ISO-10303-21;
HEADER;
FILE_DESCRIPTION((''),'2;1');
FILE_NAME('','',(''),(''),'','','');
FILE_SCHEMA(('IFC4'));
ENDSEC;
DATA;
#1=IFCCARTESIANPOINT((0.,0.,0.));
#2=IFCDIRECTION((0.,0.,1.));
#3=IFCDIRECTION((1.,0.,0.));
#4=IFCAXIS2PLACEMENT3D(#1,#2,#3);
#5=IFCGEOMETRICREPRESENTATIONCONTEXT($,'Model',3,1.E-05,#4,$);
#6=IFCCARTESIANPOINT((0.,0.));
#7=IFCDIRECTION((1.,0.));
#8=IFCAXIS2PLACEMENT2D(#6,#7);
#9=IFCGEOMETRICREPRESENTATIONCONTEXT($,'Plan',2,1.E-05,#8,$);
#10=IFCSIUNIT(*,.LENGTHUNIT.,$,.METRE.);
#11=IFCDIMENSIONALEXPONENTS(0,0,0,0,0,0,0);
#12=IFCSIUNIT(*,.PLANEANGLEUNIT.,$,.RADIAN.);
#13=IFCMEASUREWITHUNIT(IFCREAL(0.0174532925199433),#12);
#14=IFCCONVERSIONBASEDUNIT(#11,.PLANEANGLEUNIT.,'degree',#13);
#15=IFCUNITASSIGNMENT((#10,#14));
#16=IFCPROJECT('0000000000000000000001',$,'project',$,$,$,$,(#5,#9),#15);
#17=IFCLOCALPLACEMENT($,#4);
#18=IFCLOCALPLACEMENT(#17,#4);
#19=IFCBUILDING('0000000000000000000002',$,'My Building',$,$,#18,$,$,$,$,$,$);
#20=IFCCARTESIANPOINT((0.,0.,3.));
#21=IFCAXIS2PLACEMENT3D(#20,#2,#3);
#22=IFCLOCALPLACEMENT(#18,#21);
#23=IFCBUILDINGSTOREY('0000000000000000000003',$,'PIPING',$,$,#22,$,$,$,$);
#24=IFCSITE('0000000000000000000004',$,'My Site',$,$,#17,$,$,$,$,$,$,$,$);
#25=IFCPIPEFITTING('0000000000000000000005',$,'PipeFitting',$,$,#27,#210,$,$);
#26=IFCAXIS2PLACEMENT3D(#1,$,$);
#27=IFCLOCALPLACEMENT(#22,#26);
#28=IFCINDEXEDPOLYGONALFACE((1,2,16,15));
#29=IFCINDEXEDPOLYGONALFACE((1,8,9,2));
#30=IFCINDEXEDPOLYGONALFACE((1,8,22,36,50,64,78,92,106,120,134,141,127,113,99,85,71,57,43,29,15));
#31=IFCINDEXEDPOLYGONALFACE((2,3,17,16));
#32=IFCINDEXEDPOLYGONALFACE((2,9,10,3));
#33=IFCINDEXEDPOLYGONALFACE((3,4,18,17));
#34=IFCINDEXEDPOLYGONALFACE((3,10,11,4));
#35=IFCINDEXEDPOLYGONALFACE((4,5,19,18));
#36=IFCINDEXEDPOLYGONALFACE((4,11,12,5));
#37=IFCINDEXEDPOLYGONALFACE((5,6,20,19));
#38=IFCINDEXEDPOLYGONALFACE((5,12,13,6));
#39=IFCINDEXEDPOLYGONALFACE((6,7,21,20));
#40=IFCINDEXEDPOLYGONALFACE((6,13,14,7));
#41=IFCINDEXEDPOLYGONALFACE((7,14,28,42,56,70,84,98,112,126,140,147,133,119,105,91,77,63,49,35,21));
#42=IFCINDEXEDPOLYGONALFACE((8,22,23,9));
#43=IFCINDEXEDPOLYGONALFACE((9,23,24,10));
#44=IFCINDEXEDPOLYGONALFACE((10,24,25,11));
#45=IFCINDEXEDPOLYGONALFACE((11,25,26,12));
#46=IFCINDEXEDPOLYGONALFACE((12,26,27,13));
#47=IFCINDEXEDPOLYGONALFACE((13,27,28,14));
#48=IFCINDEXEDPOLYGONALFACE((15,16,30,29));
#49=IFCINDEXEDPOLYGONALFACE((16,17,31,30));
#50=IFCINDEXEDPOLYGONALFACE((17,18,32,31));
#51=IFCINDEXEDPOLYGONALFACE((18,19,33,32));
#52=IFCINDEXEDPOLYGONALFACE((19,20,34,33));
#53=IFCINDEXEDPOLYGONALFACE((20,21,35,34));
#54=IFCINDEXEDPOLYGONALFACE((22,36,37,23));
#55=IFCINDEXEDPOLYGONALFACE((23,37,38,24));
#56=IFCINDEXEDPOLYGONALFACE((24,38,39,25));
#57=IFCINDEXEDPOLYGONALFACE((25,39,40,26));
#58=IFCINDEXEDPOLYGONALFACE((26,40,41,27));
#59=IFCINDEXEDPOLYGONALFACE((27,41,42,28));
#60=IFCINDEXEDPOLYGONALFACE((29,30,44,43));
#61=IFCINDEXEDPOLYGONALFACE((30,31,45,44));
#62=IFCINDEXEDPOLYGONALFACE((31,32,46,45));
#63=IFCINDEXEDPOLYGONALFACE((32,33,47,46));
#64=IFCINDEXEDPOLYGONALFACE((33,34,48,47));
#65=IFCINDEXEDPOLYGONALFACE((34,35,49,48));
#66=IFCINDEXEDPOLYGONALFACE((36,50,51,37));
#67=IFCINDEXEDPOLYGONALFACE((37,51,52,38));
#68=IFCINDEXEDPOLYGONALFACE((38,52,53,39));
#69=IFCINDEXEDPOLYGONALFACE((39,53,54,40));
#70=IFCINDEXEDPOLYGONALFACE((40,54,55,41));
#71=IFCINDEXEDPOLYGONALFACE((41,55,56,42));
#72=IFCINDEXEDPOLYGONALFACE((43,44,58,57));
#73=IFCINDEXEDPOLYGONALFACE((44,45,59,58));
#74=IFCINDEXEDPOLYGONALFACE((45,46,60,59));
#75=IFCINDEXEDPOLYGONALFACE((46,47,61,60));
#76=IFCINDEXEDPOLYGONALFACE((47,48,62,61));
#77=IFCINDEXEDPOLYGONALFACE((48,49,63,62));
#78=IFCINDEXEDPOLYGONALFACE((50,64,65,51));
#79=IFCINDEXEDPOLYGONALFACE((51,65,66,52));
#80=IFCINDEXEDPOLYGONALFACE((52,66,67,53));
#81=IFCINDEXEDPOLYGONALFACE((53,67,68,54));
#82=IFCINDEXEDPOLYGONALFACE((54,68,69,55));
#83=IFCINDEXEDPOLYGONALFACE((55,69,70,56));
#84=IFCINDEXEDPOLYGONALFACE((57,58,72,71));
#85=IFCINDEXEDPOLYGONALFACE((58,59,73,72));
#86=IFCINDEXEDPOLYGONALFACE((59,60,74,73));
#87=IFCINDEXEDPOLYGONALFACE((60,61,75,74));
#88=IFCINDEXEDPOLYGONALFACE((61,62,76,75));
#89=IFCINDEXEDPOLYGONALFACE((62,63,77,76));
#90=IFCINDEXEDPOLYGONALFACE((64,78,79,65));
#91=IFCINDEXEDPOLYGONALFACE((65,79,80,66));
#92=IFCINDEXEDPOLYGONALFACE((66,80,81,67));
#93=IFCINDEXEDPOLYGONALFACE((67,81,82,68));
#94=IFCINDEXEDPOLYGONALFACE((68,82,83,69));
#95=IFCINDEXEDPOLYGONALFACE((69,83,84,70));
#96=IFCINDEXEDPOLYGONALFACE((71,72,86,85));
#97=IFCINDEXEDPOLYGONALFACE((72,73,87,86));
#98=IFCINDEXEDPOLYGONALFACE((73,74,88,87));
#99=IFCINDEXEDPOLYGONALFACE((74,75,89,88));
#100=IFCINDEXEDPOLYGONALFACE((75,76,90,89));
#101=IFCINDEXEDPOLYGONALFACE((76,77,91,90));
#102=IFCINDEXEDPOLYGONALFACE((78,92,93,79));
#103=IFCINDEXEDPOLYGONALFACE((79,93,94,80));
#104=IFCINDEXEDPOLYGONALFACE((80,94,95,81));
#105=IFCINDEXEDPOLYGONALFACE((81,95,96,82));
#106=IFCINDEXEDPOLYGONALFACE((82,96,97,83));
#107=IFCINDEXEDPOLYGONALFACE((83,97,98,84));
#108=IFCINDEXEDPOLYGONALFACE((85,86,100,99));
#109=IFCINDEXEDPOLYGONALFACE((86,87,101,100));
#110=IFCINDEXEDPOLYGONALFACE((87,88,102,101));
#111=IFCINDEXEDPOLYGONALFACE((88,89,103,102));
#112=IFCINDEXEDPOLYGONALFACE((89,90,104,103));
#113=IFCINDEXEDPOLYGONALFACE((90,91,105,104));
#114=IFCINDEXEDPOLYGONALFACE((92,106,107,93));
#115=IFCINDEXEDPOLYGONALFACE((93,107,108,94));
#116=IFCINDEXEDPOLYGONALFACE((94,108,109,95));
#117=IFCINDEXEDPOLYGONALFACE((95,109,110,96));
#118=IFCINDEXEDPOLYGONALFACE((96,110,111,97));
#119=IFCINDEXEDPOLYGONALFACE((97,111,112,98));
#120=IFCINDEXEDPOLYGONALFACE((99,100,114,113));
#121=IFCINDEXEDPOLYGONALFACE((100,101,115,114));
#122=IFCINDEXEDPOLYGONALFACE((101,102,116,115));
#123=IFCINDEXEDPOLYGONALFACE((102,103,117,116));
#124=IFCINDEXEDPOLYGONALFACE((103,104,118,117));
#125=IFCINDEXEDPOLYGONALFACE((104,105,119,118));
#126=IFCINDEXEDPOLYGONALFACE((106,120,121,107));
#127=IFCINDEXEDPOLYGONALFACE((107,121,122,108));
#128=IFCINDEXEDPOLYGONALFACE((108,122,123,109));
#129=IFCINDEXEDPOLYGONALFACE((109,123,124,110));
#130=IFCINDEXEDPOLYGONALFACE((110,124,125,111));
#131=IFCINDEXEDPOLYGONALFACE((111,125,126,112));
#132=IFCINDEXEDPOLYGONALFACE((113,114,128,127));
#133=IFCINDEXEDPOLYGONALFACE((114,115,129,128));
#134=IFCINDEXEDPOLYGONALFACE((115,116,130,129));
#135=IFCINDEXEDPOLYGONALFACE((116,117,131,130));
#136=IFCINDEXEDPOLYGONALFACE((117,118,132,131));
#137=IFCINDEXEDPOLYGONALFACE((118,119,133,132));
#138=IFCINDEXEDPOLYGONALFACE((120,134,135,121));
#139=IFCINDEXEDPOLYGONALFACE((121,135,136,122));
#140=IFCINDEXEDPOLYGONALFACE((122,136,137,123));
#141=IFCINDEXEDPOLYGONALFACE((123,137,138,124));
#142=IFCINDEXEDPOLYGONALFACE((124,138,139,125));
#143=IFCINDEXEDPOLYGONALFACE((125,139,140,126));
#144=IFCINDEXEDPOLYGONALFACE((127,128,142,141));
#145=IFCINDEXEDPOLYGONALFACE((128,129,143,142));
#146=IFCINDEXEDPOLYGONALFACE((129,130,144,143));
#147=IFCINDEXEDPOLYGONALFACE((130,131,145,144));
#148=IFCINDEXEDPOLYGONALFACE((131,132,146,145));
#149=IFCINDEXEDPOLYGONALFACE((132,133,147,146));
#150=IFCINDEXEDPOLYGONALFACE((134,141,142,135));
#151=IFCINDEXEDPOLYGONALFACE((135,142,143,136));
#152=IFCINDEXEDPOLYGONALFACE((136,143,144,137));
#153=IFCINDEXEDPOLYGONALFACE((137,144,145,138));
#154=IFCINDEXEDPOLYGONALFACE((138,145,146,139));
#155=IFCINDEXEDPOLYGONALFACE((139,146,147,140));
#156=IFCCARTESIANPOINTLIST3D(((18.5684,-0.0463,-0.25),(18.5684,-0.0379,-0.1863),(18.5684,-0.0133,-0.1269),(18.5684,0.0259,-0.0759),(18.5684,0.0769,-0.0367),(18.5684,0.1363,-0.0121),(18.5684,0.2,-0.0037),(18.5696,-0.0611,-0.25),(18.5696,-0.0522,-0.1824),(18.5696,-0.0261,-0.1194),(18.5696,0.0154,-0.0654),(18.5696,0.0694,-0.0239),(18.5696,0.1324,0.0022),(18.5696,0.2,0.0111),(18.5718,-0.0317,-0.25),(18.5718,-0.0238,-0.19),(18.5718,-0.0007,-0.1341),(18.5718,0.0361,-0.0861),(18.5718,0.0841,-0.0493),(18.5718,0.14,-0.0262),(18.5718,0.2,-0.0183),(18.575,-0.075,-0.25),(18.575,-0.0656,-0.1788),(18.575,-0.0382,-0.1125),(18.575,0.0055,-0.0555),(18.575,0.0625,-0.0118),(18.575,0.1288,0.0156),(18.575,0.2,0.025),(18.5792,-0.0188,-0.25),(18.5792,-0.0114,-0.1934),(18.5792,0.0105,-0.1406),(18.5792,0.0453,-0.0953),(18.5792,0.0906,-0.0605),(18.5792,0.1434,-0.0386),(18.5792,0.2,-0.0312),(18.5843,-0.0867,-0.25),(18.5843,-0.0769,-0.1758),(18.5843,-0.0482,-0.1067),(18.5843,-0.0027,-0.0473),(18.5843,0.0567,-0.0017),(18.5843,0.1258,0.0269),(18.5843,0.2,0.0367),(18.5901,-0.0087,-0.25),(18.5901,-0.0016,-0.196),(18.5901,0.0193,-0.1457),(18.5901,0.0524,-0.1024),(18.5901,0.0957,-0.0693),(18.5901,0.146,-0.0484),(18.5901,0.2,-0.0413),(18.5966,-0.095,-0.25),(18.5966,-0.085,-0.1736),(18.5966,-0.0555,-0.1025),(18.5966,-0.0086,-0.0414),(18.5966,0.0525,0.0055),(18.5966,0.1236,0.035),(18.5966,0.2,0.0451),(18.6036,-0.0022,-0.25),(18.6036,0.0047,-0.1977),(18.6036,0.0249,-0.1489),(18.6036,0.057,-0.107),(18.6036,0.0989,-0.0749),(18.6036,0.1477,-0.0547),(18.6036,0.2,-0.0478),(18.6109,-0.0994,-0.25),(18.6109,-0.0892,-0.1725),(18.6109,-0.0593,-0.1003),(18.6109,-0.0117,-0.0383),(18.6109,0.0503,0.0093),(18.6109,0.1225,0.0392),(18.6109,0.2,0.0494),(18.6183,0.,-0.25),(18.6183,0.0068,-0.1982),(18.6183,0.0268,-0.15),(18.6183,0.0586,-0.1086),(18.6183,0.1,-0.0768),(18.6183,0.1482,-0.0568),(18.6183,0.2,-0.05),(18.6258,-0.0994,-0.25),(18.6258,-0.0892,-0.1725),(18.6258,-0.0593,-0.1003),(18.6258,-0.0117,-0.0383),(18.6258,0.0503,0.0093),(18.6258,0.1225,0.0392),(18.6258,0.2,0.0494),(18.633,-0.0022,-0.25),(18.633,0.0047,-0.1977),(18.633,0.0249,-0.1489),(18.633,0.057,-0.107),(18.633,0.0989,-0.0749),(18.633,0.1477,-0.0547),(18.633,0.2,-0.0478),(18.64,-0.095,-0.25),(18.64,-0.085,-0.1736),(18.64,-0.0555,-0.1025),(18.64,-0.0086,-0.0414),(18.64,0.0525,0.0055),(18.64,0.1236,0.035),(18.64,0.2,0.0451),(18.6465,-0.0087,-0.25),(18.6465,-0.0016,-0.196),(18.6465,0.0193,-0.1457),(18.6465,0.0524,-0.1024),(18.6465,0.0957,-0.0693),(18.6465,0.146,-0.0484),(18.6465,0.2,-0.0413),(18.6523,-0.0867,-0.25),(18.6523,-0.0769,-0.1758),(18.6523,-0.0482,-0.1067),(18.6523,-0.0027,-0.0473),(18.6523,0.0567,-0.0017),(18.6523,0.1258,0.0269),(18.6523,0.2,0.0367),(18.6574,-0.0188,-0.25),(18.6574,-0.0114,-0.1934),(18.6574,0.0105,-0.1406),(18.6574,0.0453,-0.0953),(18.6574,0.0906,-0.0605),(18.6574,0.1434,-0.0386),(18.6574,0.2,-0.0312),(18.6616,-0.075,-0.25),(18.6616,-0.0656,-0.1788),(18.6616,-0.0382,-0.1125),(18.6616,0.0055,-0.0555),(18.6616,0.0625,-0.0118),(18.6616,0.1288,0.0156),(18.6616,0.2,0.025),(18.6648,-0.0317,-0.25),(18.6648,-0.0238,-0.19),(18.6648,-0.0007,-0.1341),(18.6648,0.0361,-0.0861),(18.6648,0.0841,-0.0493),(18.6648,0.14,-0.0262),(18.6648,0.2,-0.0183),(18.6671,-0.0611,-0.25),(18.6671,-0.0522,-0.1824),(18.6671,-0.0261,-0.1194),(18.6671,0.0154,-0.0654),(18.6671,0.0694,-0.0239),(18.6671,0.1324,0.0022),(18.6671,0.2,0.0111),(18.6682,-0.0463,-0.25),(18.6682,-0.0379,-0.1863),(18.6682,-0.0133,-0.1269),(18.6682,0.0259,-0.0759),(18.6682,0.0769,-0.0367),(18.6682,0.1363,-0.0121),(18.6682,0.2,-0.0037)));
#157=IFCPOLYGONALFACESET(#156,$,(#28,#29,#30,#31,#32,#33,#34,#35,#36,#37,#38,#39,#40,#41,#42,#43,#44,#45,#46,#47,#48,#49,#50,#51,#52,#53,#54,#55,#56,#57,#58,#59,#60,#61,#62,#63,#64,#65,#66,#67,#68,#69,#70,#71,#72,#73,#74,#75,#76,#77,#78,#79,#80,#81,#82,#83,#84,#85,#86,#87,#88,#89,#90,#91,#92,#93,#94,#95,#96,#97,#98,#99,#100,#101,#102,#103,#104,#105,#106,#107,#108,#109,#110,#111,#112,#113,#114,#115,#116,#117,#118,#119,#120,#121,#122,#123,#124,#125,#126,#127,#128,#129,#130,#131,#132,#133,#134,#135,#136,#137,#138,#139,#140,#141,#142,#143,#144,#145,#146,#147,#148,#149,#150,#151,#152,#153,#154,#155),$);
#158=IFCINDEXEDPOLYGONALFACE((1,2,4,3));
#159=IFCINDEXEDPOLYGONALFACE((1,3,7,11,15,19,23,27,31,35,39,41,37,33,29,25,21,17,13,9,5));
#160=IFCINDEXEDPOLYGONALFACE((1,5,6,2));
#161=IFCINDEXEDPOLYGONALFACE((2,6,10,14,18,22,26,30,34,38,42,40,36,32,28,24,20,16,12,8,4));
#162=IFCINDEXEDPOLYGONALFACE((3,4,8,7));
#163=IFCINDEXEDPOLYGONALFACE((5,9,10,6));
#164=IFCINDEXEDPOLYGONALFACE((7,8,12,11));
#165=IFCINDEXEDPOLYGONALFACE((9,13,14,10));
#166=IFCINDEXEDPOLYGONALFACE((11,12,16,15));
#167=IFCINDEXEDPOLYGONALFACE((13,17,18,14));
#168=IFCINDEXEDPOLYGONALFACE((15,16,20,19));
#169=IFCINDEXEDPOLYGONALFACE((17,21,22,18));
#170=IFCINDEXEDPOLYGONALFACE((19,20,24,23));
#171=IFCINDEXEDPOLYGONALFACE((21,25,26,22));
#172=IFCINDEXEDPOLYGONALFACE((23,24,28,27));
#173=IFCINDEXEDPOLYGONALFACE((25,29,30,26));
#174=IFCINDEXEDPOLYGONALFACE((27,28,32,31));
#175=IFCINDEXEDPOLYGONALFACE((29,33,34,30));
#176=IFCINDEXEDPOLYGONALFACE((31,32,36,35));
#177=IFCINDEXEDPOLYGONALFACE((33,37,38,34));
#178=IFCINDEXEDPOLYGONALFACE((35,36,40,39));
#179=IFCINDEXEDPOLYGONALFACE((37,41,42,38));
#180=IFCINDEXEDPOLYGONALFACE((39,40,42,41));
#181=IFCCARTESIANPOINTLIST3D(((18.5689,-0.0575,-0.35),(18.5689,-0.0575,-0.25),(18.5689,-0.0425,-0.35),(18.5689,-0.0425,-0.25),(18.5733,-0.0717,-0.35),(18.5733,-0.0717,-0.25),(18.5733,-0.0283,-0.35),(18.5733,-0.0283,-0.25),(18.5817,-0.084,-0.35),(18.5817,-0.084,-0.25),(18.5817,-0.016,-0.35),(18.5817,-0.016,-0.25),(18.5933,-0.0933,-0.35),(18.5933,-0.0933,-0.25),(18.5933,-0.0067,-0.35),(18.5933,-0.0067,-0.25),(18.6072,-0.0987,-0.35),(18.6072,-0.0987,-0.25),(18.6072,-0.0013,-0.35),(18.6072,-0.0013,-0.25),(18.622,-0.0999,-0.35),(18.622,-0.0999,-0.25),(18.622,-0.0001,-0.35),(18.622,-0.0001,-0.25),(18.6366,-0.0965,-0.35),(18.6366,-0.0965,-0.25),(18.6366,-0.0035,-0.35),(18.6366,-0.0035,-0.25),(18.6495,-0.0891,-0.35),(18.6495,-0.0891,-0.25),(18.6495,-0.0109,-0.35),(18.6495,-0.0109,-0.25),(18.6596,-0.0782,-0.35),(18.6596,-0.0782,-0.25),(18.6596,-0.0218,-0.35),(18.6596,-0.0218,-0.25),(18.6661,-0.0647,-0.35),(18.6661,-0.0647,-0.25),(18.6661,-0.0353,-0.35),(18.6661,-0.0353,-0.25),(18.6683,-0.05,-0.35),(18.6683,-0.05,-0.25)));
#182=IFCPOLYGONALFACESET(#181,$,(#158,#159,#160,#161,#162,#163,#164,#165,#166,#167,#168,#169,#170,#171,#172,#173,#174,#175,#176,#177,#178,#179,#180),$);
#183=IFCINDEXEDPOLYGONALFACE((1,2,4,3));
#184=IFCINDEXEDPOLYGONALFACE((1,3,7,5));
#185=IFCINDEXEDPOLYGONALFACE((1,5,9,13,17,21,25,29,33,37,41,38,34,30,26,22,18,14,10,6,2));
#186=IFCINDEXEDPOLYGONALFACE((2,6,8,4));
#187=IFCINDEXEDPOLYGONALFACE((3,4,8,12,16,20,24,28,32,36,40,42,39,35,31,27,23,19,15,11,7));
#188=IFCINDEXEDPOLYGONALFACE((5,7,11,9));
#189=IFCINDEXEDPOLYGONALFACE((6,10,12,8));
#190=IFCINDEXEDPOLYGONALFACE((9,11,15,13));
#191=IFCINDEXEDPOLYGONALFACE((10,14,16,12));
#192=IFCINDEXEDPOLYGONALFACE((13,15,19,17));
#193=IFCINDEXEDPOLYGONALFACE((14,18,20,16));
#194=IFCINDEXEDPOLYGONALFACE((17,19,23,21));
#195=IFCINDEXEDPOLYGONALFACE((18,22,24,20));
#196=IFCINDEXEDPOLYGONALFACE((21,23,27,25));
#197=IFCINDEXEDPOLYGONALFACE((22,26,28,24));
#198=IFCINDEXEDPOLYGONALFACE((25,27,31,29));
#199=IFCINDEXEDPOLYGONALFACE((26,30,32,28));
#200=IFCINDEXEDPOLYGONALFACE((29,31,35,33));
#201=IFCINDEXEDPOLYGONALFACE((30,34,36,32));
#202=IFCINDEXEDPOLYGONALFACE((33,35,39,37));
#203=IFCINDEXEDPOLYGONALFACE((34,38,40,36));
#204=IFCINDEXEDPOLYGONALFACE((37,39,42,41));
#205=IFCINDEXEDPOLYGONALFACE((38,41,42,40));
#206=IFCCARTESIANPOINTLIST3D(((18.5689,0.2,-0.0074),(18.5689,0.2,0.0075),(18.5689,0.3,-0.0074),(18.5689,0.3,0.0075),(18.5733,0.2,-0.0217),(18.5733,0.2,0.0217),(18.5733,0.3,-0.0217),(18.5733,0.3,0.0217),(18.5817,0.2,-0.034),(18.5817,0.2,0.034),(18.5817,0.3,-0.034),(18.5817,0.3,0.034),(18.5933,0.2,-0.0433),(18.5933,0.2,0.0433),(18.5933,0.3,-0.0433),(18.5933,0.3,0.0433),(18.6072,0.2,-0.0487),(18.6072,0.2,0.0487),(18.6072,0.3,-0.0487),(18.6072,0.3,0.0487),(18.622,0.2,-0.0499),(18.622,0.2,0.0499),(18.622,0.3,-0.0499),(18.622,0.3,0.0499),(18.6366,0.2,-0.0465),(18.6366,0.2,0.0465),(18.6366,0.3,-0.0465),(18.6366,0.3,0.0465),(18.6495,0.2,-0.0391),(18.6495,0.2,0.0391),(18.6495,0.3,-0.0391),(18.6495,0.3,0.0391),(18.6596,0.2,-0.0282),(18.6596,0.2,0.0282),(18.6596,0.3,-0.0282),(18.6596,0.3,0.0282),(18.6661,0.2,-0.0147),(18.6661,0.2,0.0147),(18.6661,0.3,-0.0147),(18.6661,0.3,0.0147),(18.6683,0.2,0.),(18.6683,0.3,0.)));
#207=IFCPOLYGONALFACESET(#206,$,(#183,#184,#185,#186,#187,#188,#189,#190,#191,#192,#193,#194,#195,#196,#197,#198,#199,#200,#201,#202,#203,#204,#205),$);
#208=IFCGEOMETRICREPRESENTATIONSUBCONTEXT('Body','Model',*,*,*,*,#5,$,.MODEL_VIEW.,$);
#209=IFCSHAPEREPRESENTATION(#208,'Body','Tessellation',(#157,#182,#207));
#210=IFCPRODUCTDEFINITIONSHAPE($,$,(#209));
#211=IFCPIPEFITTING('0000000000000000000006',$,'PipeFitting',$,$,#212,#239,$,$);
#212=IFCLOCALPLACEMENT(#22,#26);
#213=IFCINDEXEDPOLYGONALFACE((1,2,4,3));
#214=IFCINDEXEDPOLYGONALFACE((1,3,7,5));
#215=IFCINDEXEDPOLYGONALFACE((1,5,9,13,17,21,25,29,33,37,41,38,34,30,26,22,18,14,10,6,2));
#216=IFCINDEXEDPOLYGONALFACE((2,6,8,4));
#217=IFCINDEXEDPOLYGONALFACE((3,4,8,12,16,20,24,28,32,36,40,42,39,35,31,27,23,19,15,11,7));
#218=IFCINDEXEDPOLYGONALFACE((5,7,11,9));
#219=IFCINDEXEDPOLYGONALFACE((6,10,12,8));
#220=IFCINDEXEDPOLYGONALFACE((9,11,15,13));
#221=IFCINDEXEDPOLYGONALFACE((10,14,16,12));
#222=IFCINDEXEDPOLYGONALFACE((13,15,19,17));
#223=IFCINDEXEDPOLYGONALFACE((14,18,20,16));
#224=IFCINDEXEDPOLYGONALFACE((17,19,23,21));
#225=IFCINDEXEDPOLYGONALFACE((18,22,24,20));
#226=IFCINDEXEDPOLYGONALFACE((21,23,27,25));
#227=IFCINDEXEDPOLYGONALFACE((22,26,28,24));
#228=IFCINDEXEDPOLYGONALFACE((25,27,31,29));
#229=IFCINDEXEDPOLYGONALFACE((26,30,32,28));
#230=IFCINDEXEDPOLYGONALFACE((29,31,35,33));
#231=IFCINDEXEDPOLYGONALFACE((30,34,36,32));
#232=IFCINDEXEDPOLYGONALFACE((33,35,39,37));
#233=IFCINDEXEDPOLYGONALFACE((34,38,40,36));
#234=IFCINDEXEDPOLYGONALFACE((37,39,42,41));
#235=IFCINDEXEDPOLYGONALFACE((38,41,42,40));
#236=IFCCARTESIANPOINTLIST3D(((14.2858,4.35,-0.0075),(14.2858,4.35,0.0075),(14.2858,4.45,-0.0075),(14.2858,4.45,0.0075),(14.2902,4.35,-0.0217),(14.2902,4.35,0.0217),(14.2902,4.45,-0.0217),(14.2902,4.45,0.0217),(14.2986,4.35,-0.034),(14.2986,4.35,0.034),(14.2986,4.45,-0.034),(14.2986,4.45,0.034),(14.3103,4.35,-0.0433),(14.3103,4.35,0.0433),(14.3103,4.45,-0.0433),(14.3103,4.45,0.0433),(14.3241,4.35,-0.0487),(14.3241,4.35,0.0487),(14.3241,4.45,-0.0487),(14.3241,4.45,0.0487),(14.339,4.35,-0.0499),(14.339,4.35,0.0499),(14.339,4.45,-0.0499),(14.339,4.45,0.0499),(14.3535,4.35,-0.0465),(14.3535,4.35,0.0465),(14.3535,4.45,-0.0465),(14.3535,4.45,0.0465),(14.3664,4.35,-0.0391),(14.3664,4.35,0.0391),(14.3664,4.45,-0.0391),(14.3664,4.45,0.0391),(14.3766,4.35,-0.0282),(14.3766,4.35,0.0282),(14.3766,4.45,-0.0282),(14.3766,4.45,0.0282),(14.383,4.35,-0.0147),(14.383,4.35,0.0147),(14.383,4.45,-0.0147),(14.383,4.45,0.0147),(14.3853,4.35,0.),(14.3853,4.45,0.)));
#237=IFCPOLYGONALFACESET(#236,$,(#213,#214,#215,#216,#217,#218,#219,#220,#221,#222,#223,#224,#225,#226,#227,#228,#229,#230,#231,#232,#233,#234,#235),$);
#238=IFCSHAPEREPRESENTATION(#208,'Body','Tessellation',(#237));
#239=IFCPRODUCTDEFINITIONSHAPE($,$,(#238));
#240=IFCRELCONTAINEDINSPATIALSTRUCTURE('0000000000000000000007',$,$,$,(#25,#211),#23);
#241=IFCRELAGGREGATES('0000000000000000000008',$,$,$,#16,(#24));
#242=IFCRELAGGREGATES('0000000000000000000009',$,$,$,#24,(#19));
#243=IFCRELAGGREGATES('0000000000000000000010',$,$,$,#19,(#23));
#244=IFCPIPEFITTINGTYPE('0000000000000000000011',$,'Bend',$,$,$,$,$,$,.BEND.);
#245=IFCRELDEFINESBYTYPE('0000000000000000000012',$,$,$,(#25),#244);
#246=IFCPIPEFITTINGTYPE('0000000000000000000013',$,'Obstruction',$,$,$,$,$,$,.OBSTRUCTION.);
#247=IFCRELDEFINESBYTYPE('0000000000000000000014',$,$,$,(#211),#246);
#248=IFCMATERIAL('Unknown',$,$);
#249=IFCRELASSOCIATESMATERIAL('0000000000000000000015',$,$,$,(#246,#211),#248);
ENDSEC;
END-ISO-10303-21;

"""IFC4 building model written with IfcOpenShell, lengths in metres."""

from ifc_helpers import new_model, entity, si_unit, converted_unit, frame, origin_with_axes, origin_2d_with_axis, place, context, subcontext, project, spatial, circle, extrude, source, transform, mapped, material, material_profile, profile_set, profile_usage, type_object, type_shapes, element, save


model = new_model("IFC4")

# Units and contexts
model_context = context("Model", 3, precision=1e-05, world=origin_with_axes())
plan_context = context("Plan", 2, precision=1e-05, world=origin_2d_with_axis())
body_context = subcontext(model_context, "Body", "Model", "MODEL_VIEW")
ifc_project = project(units=[si_unit("LENGTHUNIT", "METRE"), converted_unit("PLANEANGLEUNIT", "degree", entity("IfcReal", 0.0174532925199433), si_unit("PLANEANGLEUNIT", "RADIAN"), dimensions=[0, 0, 0, 0, 0, 0, 0])], contexts=[model_context, plan_context])

# Site, building, storey
site_placement = place(None, origin_with_axes())
site = spatial("IfcSite", under=ifc_project, at=site_placement, Name="My Site")
building_placement = place(site_placement, origin_with_axes())
building = spatial("IfcBuilding", under=site, at=building_placement, Name="My Building")
storey_placement = place(building_placement, frame((0.0, 0.0, 3.0), z_axis=(0.0, 0.0, 1.0), x_axis=(1.0, 0.0, 0.0)))
storey = spatial("IfcBuildingStorey", under=building, at=storey_placement, Name="PIPING")

# Shared definitions
ifc_material = material(Name="Unknown")

# Pipe fittings
pipe_fitting_type_1 = type_object("IfcPipeFittingType", Name="Bend", PredefinedType="BEND")
shared_shape = source(origin_with_axes(), body_context, "Body", "SolidModel", [
    entity("IfcSweptDiskSolid", entity("IfcIndexedPolyCurve", entity("IfcCartesianPointList3D", [[0.0, 0.0, -0.1], [0.0, -0.0732, -0.2768], [0.0, -0.25, -0.35]]), [entity("IfcArcIndex", [1, 2, 3])]), 0.05),
    extrude(circle(Radius=0.05), origin_with_axes(), (0.0, 0.0, -1.0), 0.1),
    extrude(circle(Radius=0.05), frame((0.0, -0.25, -0.35), z_axis=(0.0, -1.0, 0.0), x_axis=(1.0, 0.0, 0.0)), (0.0, 0.0, 1.0), 0.1),
])
type_shapes(pipe_fitting_type_1, [shared_shape])
for number, where, z_axis, x_axis, name in (
    (1, (18.6183, -0.05, -0.35), (0.0, 0.0, -1.0), (1.0, 0.0, 0.0), "PipeFitting"),
):
    element("IfcPipeFitting", number, at=place(storey_placement, frame(where, z_axis=z_axis, x_axis=x_axis)), inside=storey, type_object=pipe_fitting_type_1, Name=name, context=body_context, shape_type="MappedRepresentation", body=[
        mapped(shared_shape, transform((0.0, 0.0, 0.0), x_axis=(1.0, 0.0, 0.0), y_axis=(0.0, 1.0, 0.0), z_axis=(0.0, 0.0, 1.0), scale=1.0)),
    ])
ifc_material_profile_1 = material_profile(ifc_material, circle(Radius=0.05))
ifc_profile_set_1 = profile_set([ifc_material_profile_1])
ifc_profile_usage_1 = profile_usage(ifc_profile_set_1, cardinal=5)
pipe_fitting_type_2 = type_object("IfcPipeFittingType", Name="Obstruction", PredefinedType="OBSTRUCTION", material=ifc_profile_set_1)
pipe_fitting_1_placement = place(storey_placement, frame((14.3353, 4.45, 0.0), z_axis=(0.0, -1.0, 0.0), x_axis=(1.0, 0.0, 0.0)))
element("IfcPipeFitting", 2, at=pipe_fitting_1_placement, inside=storey, type_object=pipe_fitting_type_2, material=ifc_profile_usage_1, Name="PipeFitting", context=body_context, shape_type="SweptSolid", body=[
    extrude(circle(Radius=0.05), origin_with_axes(), (0.0, 0.0, 1.0), 0.1),
])

save(model, "model.ifc")
